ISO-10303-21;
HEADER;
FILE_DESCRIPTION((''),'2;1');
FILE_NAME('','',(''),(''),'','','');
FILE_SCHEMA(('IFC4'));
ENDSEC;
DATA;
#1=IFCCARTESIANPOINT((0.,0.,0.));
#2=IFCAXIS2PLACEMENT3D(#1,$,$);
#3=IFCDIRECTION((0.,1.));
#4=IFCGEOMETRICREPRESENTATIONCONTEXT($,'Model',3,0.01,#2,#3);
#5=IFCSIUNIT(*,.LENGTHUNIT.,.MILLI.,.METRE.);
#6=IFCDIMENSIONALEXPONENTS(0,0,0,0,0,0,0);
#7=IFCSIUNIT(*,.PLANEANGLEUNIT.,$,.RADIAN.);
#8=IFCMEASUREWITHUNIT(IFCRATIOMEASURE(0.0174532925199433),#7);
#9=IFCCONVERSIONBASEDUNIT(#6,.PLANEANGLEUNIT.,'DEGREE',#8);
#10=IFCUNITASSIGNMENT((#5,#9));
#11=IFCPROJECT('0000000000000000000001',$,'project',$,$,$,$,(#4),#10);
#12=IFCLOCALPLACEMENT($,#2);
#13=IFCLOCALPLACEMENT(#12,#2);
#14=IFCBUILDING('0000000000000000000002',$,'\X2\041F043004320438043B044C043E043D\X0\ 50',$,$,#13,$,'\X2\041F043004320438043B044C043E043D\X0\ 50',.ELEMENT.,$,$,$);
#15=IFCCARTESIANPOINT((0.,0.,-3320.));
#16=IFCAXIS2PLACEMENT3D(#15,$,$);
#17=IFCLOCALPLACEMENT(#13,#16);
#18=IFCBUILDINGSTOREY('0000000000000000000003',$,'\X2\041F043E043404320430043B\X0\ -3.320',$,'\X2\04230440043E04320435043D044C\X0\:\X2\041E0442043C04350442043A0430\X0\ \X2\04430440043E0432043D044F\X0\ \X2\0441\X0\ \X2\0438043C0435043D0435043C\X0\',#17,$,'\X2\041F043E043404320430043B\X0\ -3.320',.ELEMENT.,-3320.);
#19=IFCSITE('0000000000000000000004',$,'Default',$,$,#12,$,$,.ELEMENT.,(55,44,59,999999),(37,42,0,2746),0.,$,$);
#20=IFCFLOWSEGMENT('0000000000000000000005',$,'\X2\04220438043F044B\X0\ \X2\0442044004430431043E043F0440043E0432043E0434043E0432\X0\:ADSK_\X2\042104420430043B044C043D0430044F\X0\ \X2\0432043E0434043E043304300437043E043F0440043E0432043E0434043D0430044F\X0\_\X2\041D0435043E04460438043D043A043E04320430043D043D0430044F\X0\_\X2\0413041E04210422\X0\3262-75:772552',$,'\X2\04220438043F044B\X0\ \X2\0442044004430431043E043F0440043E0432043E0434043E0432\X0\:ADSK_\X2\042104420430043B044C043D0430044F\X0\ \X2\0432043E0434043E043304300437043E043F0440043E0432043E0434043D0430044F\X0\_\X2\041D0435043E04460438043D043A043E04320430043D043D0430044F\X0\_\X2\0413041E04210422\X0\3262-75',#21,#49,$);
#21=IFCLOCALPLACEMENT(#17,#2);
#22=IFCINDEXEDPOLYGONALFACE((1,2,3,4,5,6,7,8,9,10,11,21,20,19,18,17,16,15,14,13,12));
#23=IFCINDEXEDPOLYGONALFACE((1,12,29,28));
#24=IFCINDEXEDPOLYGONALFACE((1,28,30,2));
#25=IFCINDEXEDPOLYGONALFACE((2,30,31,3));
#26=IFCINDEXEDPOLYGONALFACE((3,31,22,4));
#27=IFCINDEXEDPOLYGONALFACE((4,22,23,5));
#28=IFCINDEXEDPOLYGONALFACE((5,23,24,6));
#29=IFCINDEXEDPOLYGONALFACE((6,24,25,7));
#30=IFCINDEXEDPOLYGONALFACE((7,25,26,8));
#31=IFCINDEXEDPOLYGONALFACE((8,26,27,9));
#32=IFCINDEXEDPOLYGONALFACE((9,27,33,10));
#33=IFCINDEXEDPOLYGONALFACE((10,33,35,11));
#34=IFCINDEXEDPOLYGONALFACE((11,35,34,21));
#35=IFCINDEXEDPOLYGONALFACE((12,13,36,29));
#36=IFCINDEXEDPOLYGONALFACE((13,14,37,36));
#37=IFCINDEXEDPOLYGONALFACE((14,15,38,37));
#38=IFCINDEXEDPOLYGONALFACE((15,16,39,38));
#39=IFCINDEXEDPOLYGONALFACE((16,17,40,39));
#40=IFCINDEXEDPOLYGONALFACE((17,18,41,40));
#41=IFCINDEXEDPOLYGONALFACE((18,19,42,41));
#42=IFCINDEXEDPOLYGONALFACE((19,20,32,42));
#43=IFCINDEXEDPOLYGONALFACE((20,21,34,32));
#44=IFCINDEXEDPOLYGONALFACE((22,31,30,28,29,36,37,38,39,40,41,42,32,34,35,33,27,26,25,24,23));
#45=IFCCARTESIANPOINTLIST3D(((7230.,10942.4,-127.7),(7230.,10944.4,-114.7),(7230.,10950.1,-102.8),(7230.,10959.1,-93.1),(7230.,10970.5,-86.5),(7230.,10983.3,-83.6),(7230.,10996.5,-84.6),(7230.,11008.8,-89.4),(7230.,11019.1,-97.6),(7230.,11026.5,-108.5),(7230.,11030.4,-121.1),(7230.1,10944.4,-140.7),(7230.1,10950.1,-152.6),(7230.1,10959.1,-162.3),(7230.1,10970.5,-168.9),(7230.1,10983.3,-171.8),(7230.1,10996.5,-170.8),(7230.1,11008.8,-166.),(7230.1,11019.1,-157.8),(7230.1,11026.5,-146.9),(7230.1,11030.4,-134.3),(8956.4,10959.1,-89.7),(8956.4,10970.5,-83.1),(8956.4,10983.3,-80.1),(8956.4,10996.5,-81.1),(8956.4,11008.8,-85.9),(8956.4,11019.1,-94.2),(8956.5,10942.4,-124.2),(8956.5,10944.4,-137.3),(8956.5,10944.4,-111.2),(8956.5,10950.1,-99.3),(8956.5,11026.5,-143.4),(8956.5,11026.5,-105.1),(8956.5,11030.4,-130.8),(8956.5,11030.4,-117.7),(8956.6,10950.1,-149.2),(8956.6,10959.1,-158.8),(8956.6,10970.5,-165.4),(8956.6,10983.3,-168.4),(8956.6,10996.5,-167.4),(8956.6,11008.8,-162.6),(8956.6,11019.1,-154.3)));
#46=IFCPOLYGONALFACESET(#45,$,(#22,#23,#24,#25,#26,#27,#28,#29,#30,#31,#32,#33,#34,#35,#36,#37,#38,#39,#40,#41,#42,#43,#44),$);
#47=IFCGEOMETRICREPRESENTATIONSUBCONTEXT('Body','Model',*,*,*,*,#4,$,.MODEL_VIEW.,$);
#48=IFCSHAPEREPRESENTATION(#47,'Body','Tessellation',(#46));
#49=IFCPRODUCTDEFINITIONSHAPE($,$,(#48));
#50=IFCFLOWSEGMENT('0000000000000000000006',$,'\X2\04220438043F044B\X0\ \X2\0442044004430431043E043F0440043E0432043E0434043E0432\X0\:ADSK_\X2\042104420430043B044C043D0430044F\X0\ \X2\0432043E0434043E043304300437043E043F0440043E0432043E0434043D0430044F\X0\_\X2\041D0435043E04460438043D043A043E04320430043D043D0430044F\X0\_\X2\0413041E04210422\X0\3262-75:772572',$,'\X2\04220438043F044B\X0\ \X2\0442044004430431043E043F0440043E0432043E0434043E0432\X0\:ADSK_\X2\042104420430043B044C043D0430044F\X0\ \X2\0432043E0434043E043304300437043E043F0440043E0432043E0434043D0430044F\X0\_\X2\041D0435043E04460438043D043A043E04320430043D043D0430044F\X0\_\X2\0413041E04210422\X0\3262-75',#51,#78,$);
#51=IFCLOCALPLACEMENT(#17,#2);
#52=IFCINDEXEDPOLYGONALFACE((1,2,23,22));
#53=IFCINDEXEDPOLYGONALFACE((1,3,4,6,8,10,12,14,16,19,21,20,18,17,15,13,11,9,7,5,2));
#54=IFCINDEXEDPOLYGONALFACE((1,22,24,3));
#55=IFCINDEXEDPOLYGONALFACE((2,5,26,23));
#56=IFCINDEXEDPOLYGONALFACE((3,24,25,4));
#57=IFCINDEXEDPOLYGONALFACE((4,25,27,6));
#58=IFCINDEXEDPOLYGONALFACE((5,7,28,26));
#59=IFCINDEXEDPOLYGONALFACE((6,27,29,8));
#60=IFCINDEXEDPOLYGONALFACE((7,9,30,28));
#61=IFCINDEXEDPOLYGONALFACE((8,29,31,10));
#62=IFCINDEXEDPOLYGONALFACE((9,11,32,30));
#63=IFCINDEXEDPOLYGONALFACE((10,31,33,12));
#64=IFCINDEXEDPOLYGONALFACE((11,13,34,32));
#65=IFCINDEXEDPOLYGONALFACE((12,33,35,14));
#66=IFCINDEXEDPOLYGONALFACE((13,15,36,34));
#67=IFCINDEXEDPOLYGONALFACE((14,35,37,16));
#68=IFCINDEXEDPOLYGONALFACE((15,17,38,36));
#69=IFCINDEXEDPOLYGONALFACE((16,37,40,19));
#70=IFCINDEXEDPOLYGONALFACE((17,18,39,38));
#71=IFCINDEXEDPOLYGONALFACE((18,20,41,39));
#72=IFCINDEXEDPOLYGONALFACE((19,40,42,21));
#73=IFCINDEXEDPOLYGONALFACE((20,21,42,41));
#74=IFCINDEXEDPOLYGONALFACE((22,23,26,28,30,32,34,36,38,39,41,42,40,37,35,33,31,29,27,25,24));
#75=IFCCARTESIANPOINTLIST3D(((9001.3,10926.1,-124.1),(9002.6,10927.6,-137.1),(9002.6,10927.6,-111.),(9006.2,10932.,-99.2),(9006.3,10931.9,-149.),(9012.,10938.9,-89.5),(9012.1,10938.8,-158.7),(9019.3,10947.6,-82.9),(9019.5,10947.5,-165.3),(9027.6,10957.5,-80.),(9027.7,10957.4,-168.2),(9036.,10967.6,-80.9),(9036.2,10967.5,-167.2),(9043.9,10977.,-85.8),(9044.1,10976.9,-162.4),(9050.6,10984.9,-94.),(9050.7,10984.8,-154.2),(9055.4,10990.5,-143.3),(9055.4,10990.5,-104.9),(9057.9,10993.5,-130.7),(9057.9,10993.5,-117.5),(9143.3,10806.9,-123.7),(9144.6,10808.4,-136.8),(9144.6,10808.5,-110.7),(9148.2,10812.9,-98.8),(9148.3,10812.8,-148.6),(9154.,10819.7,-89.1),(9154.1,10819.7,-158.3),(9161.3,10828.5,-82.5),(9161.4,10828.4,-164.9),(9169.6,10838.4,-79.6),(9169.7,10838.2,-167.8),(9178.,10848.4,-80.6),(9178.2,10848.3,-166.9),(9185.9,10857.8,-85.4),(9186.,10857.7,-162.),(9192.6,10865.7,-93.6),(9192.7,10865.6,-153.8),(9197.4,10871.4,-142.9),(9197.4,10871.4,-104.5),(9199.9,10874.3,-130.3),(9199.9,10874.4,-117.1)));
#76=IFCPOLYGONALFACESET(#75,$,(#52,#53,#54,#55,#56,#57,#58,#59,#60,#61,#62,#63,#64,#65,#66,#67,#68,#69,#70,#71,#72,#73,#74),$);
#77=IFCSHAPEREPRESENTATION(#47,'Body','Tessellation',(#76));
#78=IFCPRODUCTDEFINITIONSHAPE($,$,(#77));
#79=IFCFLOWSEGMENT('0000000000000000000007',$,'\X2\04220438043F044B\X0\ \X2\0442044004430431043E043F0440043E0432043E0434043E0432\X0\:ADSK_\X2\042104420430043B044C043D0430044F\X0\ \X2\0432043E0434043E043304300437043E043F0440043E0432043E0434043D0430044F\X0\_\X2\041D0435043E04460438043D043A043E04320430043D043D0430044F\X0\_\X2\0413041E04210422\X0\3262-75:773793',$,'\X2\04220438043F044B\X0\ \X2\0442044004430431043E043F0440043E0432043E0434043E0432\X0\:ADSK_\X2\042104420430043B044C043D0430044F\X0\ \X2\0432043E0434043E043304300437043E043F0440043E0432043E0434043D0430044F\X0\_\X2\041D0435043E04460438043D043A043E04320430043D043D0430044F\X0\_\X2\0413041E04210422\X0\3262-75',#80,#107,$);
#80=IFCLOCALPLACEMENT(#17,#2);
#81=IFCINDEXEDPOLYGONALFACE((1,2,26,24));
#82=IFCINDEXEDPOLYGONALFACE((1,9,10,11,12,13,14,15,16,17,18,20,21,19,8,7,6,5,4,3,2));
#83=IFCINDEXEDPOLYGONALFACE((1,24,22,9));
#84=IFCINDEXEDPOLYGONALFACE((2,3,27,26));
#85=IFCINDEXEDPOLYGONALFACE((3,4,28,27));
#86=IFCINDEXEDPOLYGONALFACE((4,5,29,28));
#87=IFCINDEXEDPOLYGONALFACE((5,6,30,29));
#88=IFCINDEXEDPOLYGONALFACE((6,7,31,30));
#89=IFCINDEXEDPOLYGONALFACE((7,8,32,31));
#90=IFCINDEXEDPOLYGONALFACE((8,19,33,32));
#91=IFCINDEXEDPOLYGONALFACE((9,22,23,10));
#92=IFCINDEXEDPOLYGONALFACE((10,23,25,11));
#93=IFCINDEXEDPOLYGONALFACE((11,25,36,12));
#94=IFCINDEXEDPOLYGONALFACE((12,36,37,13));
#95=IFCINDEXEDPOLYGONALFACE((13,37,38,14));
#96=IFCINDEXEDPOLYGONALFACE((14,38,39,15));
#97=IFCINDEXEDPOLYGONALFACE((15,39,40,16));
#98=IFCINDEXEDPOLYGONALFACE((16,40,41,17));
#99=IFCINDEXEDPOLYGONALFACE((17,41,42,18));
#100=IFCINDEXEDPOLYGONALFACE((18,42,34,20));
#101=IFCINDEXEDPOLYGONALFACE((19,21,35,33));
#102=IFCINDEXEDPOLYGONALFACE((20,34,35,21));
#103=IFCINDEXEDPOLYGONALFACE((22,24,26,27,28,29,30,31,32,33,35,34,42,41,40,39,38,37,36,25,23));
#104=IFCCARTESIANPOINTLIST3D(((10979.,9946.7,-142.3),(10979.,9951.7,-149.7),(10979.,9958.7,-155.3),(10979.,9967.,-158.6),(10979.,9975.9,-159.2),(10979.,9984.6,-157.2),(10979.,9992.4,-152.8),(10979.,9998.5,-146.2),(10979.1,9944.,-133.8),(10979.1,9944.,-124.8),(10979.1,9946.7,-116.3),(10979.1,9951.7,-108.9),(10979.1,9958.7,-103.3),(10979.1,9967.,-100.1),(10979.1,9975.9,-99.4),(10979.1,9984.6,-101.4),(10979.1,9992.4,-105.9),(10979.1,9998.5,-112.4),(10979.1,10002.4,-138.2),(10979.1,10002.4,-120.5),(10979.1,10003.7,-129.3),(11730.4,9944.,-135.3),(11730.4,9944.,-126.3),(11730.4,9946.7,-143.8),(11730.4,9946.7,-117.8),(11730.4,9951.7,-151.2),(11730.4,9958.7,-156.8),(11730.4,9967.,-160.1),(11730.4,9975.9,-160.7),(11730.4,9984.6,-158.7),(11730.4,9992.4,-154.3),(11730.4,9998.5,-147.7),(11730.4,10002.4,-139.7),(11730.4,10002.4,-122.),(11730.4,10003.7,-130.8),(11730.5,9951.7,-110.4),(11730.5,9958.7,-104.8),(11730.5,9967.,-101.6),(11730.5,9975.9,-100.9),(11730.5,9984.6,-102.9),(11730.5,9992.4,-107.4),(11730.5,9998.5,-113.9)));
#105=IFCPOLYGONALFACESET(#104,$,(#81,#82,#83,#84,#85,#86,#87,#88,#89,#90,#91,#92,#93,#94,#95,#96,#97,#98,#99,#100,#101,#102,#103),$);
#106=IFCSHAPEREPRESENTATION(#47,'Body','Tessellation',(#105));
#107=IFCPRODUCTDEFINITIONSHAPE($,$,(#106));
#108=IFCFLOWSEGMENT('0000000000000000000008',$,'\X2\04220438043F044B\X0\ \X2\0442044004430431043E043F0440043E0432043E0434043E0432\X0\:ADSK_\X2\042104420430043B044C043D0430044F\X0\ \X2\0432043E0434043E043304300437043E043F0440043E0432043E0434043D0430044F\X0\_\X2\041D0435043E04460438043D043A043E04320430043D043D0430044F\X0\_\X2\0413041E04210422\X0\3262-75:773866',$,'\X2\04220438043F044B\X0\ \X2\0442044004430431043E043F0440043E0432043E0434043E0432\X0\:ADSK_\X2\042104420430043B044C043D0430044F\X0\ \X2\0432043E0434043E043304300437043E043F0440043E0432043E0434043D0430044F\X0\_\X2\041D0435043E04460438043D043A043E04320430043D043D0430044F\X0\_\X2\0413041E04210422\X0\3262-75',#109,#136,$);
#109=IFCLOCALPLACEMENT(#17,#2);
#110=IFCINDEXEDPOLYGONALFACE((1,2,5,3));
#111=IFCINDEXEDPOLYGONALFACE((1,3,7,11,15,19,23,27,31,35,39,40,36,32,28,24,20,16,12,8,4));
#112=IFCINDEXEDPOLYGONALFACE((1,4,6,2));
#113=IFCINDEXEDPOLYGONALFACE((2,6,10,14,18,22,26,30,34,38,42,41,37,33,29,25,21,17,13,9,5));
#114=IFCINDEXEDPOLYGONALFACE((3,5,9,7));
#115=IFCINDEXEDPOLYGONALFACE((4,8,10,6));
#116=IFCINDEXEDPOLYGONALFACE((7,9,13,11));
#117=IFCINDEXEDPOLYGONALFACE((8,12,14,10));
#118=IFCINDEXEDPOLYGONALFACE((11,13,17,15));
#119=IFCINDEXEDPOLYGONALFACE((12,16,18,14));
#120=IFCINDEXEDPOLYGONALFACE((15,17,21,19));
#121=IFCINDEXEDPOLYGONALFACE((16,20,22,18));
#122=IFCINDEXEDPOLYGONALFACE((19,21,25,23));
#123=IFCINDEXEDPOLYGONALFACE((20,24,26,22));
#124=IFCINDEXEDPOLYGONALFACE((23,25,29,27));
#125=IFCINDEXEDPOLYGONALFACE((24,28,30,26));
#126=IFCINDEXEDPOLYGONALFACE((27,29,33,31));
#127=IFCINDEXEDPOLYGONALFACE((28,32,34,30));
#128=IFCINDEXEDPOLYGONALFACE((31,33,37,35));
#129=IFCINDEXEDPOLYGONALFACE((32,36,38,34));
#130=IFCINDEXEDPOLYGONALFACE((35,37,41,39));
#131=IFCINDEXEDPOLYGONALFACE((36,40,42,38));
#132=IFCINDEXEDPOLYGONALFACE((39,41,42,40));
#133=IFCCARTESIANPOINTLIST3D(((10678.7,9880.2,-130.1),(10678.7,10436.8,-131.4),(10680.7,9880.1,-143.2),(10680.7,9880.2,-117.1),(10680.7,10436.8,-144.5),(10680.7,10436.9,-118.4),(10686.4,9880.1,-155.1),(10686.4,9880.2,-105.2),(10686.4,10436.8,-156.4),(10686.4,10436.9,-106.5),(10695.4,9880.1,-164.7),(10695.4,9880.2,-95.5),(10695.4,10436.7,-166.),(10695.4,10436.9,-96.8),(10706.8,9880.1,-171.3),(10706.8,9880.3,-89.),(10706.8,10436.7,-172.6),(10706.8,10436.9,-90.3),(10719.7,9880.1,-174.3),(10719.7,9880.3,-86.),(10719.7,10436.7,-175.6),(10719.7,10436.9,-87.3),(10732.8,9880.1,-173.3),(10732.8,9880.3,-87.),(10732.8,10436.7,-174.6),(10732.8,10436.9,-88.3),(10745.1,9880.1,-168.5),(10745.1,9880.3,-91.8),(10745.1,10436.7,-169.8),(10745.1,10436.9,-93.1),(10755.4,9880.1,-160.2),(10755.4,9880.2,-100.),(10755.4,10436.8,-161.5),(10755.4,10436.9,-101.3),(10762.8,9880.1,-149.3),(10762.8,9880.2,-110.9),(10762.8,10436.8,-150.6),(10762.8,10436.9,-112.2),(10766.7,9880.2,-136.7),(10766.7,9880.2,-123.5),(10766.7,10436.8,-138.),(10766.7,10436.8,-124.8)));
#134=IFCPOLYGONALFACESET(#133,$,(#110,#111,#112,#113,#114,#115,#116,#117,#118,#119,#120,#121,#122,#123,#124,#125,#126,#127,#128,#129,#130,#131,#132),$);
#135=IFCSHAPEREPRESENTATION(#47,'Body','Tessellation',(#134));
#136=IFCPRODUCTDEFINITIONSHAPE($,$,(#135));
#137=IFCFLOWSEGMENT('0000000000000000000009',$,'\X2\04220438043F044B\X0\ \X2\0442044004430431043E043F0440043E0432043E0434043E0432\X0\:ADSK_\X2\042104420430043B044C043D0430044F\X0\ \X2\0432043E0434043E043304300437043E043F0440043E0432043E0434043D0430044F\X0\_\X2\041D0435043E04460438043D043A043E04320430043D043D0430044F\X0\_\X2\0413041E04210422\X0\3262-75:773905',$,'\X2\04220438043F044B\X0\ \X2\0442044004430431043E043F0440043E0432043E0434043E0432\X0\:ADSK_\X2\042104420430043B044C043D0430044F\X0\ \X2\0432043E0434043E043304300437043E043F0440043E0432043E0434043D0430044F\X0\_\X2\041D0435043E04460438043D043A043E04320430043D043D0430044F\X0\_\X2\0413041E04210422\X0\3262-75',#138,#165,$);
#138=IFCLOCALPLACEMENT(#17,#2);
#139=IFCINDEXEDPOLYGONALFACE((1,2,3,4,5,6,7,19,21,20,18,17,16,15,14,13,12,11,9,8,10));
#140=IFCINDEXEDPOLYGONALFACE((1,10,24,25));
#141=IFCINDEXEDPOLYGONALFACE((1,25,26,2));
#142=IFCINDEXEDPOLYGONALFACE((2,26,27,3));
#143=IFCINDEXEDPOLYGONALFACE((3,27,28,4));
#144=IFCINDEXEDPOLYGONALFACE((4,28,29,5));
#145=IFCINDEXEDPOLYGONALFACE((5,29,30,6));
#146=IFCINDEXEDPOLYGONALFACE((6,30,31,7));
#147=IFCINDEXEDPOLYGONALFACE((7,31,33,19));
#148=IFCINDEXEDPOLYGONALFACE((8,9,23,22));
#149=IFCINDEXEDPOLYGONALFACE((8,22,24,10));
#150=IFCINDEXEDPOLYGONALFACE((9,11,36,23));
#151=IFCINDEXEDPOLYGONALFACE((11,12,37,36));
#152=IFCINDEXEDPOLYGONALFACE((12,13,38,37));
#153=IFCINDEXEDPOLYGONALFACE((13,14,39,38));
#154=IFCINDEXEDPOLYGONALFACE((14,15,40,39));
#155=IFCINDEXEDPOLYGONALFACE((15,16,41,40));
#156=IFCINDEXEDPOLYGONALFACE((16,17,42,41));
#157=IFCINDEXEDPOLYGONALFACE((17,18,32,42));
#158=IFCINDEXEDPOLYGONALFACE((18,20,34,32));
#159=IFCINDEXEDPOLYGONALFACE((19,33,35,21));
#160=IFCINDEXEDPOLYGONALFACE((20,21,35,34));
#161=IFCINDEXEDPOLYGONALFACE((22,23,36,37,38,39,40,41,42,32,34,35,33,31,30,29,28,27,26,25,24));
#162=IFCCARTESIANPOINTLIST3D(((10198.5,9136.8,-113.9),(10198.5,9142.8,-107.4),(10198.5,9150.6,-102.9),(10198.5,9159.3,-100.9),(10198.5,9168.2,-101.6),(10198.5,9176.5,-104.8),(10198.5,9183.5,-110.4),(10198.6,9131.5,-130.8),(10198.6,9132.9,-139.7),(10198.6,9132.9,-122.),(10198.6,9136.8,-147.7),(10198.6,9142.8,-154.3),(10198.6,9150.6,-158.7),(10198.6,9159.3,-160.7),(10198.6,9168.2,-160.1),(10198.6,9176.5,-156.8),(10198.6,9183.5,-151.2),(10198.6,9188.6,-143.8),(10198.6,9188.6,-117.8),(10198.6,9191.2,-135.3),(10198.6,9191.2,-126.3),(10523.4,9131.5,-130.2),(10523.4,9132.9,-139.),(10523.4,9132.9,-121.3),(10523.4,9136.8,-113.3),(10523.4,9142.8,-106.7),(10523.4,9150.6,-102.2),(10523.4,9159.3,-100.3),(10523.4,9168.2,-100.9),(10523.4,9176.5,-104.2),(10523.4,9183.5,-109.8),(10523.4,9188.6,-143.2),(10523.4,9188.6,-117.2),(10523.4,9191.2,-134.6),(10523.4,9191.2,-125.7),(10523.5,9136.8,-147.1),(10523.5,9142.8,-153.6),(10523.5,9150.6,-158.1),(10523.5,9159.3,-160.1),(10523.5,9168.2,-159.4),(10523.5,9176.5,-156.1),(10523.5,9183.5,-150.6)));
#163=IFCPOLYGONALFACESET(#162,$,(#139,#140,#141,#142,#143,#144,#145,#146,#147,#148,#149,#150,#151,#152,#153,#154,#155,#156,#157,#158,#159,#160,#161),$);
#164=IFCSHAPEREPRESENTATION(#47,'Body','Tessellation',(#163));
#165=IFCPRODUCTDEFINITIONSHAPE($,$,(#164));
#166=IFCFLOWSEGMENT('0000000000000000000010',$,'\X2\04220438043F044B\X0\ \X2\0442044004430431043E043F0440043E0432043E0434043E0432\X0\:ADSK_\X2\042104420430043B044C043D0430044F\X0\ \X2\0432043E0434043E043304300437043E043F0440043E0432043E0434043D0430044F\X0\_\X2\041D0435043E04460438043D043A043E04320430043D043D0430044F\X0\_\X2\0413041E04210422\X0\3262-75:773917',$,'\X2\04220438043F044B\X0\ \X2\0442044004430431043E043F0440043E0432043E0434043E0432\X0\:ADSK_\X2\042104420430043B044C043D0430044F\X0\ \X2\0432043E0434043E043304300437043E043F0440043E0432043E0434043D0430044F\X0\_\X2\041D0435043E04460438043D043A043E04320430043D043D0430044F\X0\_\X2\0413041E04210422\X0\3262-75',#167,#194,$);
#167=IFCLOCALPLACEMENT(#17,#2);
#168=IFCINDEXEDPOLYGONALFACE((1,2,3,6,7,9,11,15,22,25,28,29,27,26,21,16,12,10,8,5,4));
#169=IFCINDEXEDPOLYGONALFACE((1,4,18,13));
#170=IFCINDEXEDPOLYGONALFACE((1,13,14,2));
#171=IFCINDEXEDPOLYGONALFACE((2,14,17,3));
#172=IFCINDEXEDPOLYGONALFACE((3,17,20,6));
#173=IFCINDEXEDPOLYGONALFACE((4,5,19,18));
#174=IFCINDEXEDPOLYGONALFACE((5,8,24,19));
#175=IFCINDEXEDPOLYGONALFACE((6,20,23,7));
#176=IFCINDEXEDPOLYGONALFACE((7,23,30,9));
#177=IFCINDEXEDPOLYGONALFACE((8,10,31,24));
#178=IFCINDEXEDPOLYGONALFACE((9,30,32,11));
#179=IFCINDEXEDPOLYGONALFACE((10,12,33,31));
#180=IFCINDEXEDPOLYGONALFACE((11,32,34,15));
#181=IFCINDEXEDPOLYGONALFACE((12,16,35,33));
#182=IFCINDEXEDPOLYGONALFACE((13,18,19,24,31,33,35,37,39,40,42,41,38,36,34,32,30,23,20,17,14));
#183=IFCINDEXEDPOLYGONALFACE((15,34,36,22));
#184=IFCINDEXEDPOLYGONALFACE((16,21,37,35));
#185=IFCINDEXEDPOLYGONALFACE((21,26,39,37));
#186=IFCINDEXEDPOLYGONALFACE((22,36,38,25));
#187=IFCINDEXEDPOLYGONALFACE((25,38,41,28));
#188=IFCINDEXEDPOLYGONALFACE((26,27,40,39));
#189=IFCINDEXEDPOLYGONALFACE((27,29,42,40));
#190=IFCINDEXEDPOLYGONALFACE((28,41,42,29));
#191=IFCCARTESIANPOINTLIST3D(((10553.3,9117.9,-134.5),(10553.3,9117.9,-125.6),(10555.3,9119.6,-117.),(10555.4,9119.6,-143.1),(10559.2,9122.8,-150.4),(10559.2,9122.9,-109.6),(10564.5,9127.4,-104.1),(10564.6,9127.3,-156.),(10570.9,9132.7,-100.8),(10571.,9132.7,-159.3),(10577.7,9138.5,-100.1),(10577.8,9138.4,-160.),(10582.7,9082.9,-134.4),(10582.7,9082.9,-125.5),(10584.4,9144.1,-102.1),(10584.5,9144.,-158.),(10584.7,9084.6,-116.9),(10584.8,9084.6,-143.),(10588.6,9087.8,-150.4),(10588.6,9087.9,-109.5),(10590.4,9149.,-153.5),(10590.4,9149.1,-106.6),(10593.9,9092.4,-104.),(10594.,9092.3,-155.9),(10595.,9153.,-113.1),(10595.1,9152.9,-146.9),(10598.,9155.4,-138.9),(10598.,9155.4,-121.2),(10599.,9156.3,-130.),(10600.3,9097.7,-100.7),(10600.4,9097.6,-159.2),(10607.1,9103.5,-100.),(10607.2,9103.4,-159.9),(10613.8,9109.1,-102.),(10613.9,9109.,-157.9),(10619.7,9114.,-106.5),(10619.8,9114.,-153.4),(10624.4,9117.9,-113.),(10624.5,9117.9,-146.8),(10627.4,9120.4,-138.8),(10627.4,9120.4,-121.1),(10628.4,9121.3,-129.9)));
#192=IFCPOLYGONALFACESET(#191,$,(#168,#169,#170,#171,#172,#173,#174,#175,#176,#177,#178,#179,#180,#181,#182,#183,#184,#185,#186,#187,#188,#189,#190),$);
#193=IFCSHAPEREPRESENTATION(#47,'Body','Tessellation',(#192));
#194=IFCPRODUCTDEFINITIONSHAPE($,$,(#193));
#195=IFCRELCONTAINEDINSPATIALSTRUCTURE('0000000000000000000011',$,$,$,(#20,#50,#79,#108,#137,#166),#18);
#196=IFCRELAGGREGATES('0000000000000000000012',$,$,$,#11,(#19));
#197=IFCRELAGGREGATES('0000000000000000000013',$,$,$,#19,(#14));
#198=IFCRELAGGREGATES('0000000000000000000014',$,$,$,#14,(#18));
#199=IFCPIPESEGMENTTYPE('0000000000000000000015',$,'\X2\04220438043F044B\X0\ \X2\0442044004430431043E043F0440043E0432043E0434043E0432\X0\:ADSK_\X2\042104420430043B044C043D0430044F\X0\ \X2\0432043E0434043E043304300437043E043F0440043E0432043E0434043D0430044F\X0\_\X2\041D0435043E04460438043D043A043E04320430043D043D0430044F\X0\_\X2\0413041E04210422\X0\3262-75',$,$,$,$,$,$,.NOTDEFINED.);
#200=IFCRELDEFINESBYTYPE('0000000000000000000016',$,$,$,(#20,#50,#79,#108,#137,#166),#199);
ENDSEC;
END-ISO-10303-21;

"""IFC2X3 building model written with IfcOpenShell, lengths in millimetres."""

from ifc_helpers import new_model, entity, si_unit, converted_unit, direction, frame, frame_2d, origin, origin_2d_with_axis, place, context, subcontext, project, spatial, circle, extrude, type_object, element, save


model = new_model("IFC2X3")

# Units and contexts
model_context = context("Model", 3, precision=0.01, world=origin(), true_north=direction((0.0, 1.0)))
body_context = subcontext(model_context, "Body", "Model", "MODEL_VIEW")
ifc_project = project(units=[si_unit("LENGTHUNIT", "METRE", prefix="MILLI"), converted_unit("PLANEANGLEUNIT", "DEGREE", entity("IfcRatioMeasure", 0.0174532925199433), si_unit("PLANEANGLEUNIT", "RADIAN"), dimensions=[0, 0, 0, 0, 0, 0, 0])], contexts=[model_context])

# Site, building, storey
site_placement = place(None, origin())
site = spatial("IfcSite", under=ifc_project, at=site_placement, Name="Default", CompositionType="ELEMENT", RefLatitude=(55, 44, 59, 999999), RefLongitude=(37, 42, 0, 2746), RefElevation=0.0)
building_placement = place(site_placement, origin())
building = spatial("IfcBuilding", under=site, at=building_placement, Name="Павильон 50", LongName="Павильон 50", CompositionType="ELEMENT")
storey_placement = place(building_placement, frame((0.0, 0.0, -3320.0)))
storey = spatial("IfcBuildingStorey", under=building, at=storey_placement, Name="Подвал -3.320", ObjectType="Уровень:Отметка уровня с именем", LongName="Подвал -3.320", CompositionType="ELEMENT", Elevation=-3320.0)

# Flow segments
pipe_segment_type = type_object("IfcPipeSegmentType", Name="Типы трубопроводов:ADSK_Стальная водогазопроводная_Неоцинкованная_ГОСТ3262-75", PredefinedType="NOTDEFINED")
flow_segment_1_placement = place(storey_placement, frame((7230.0, 10940.8, -173.5)))
element("IfcFlowSegment", 1, at=flow_segment_1_placement, inside=storey, type_object=pipe_segment_type, Name="Типы трубопроводов:ADSK_Стальная водогазопроводная_Неоцинкованная_ГОСТ3262-75:772552", ObjectType="Типы трубопроводов:ADSK_Стальная водогазопроводная_Неоцинкованная_ГОСТ3262-75", context=body_context, shape_type="SweptSolid", body=[
    extrude(circle(Radius=44.2, at=origin_2d_with_axis()), frame((0.1, 45.8, 45.8), z_axis=(0.999998, 0.0, 0.002), x_axis=(0.0, -1.0, 0.0)), (0.0, 0.0, 1.0), 1726.5),
])
flow_segment_2_placement = place(storey_placement, frame((8999.7, 10805.3, -169.9)))
element("IfcFlowSegment", 2, at=flow_segment_2_placement, inside=storey, type_object=pipe_segment_type, Name="Типы трубопроводов:ADSK_Стальная водогазопроводная_Неоцинкованная_ГОСТ3262-75:772572", ObjectType="Типы трубопроводов:ADSK_Стальная водогазопроводная_Неоцинкованная_ГОСТ3262-75", context=body_context, shape_type="SweptSolid", body=[
    extrude(circle(Radius=44.2, at=origin_2d_with_axis()), frame((30.0, 154.6, 45.8), z_axis=(0.766043, -0.642786, 0.002), x_axis=(-0.642788, -0.766044, 0.0)), (0.0, 0.0, 1.0), 185.3),
])
flow_segment_3_placement = place(storey_placement, frame((10979.0, 9942.1, -162.4)))
element("IfcFlowSegment", 3, at=flow_segment_3_placement, inside=storey, type_object=pipe_segment_type, Name="Типы трубопроводов:ADSK_Стальная водогазопроводная_Неоцинкованная_ГОСТ3262-75:773793", ObjectType="Типы трубопроводов:ADSK_Стальная водогазопроводная_Неоцинкованная_ГОСТ3262-75", context=body_context, shape_type="SweptSolid", body=[
    extrude(circle(Radius=30.0, at=origin_2d_with_axis()), frame((0.1, 31.6, 33.1), z_axis=(0.999998, 0.0, -0.002), x_axis=(0.0, 1.0, 0.0)), (0.0, 0.0, 1.0), 751.4),
])
flow_segment_4_placement = place(storey_placement, frame((10677.1, 9880.1, -177.3)))
element("IfcFlowSegment", 4, at=flow_segment_4_placement, inside=storey, type_object=pipe_segment_type, Name="Типы трубопроводов:ADSK_Стальная водогазопроводная_Неоцинкованная_ГОСТ3262-75:773866", ObjectType="Типы трубопроводов:ADSK_Стальная водогазопроводная_Неоцинкованная_ГОСТ3262-75", context=body_context, shape_type="SweptSolid", body=[
    extrude(circle(Radius=44.2, at=origin_2d_with_axis()), frame((45.8, 556.8, 45.8), z_axis=(0.0, -0.999997, 0.002331), x_axis=(-1.0, 0.0, 0.0)), (0.0, 0.0, 1.0), 556.7),
])
flow_segment_5_placement = place(storey_placement, frame((10198.5, 9129.9, -162.4)))
element("IfcFlowSegment", 5, at=flow_segment_5_placement, inside=storey, type_object=pipe_segment_type, Name="Типы трубопроводов:ADSK_Стальная водогазопроводная_Неоцинкованная_ГОСТ3262-75:773905", ObjectType="Типы трубопроводов:ADSK_Стальная водогазопроводная_Неоцинкованная_ГОСТ3262-75", context=body_context, shape_type="SweptSolid", body=[
    extrude(circle(Radius=30.0, at=frame_2d((0.0, 0.0), x_axis=(1.0, 0.0))), frame((0.1, 31.6, 31.6), z_axis=(0.999998, 0.0, 0.002), x_axis=(0.0, -1.0, 0.0)), (0.0, 0.0, 1.0), 324.8),
])
flow_segment_6_placement = place(storey_placement, frame((10551.5, 9081.1, -161.6)))
element("IfcFlowSegment", 6, at=flow_segment_6_placement, inside=storey, type_object=pipe_segment_type, Name="Типы трубопроводов:ADSK_Стальная водогазопроводная_Неоцинкованная_ГОСТ3262-75:773917", ObjectType="Типы трубопроводов:ADSK_Стальная водогазопроводная_Неоцинкованная_ГОСТ3262-75", context=body_context, shape_type="SweptSolid", body=[
    extrude(circle(Radius=30.0, at=origin_2d_with_axis()), frame((24.6, 55.9, 31.6), z_axis=(0.642786, -0.766043, 0.002), x_axis=(0.766044, 0.642788, 0.0)), (0.0, 0.0, 1.0), 45.7),
])

save(model, "model.ifc")
